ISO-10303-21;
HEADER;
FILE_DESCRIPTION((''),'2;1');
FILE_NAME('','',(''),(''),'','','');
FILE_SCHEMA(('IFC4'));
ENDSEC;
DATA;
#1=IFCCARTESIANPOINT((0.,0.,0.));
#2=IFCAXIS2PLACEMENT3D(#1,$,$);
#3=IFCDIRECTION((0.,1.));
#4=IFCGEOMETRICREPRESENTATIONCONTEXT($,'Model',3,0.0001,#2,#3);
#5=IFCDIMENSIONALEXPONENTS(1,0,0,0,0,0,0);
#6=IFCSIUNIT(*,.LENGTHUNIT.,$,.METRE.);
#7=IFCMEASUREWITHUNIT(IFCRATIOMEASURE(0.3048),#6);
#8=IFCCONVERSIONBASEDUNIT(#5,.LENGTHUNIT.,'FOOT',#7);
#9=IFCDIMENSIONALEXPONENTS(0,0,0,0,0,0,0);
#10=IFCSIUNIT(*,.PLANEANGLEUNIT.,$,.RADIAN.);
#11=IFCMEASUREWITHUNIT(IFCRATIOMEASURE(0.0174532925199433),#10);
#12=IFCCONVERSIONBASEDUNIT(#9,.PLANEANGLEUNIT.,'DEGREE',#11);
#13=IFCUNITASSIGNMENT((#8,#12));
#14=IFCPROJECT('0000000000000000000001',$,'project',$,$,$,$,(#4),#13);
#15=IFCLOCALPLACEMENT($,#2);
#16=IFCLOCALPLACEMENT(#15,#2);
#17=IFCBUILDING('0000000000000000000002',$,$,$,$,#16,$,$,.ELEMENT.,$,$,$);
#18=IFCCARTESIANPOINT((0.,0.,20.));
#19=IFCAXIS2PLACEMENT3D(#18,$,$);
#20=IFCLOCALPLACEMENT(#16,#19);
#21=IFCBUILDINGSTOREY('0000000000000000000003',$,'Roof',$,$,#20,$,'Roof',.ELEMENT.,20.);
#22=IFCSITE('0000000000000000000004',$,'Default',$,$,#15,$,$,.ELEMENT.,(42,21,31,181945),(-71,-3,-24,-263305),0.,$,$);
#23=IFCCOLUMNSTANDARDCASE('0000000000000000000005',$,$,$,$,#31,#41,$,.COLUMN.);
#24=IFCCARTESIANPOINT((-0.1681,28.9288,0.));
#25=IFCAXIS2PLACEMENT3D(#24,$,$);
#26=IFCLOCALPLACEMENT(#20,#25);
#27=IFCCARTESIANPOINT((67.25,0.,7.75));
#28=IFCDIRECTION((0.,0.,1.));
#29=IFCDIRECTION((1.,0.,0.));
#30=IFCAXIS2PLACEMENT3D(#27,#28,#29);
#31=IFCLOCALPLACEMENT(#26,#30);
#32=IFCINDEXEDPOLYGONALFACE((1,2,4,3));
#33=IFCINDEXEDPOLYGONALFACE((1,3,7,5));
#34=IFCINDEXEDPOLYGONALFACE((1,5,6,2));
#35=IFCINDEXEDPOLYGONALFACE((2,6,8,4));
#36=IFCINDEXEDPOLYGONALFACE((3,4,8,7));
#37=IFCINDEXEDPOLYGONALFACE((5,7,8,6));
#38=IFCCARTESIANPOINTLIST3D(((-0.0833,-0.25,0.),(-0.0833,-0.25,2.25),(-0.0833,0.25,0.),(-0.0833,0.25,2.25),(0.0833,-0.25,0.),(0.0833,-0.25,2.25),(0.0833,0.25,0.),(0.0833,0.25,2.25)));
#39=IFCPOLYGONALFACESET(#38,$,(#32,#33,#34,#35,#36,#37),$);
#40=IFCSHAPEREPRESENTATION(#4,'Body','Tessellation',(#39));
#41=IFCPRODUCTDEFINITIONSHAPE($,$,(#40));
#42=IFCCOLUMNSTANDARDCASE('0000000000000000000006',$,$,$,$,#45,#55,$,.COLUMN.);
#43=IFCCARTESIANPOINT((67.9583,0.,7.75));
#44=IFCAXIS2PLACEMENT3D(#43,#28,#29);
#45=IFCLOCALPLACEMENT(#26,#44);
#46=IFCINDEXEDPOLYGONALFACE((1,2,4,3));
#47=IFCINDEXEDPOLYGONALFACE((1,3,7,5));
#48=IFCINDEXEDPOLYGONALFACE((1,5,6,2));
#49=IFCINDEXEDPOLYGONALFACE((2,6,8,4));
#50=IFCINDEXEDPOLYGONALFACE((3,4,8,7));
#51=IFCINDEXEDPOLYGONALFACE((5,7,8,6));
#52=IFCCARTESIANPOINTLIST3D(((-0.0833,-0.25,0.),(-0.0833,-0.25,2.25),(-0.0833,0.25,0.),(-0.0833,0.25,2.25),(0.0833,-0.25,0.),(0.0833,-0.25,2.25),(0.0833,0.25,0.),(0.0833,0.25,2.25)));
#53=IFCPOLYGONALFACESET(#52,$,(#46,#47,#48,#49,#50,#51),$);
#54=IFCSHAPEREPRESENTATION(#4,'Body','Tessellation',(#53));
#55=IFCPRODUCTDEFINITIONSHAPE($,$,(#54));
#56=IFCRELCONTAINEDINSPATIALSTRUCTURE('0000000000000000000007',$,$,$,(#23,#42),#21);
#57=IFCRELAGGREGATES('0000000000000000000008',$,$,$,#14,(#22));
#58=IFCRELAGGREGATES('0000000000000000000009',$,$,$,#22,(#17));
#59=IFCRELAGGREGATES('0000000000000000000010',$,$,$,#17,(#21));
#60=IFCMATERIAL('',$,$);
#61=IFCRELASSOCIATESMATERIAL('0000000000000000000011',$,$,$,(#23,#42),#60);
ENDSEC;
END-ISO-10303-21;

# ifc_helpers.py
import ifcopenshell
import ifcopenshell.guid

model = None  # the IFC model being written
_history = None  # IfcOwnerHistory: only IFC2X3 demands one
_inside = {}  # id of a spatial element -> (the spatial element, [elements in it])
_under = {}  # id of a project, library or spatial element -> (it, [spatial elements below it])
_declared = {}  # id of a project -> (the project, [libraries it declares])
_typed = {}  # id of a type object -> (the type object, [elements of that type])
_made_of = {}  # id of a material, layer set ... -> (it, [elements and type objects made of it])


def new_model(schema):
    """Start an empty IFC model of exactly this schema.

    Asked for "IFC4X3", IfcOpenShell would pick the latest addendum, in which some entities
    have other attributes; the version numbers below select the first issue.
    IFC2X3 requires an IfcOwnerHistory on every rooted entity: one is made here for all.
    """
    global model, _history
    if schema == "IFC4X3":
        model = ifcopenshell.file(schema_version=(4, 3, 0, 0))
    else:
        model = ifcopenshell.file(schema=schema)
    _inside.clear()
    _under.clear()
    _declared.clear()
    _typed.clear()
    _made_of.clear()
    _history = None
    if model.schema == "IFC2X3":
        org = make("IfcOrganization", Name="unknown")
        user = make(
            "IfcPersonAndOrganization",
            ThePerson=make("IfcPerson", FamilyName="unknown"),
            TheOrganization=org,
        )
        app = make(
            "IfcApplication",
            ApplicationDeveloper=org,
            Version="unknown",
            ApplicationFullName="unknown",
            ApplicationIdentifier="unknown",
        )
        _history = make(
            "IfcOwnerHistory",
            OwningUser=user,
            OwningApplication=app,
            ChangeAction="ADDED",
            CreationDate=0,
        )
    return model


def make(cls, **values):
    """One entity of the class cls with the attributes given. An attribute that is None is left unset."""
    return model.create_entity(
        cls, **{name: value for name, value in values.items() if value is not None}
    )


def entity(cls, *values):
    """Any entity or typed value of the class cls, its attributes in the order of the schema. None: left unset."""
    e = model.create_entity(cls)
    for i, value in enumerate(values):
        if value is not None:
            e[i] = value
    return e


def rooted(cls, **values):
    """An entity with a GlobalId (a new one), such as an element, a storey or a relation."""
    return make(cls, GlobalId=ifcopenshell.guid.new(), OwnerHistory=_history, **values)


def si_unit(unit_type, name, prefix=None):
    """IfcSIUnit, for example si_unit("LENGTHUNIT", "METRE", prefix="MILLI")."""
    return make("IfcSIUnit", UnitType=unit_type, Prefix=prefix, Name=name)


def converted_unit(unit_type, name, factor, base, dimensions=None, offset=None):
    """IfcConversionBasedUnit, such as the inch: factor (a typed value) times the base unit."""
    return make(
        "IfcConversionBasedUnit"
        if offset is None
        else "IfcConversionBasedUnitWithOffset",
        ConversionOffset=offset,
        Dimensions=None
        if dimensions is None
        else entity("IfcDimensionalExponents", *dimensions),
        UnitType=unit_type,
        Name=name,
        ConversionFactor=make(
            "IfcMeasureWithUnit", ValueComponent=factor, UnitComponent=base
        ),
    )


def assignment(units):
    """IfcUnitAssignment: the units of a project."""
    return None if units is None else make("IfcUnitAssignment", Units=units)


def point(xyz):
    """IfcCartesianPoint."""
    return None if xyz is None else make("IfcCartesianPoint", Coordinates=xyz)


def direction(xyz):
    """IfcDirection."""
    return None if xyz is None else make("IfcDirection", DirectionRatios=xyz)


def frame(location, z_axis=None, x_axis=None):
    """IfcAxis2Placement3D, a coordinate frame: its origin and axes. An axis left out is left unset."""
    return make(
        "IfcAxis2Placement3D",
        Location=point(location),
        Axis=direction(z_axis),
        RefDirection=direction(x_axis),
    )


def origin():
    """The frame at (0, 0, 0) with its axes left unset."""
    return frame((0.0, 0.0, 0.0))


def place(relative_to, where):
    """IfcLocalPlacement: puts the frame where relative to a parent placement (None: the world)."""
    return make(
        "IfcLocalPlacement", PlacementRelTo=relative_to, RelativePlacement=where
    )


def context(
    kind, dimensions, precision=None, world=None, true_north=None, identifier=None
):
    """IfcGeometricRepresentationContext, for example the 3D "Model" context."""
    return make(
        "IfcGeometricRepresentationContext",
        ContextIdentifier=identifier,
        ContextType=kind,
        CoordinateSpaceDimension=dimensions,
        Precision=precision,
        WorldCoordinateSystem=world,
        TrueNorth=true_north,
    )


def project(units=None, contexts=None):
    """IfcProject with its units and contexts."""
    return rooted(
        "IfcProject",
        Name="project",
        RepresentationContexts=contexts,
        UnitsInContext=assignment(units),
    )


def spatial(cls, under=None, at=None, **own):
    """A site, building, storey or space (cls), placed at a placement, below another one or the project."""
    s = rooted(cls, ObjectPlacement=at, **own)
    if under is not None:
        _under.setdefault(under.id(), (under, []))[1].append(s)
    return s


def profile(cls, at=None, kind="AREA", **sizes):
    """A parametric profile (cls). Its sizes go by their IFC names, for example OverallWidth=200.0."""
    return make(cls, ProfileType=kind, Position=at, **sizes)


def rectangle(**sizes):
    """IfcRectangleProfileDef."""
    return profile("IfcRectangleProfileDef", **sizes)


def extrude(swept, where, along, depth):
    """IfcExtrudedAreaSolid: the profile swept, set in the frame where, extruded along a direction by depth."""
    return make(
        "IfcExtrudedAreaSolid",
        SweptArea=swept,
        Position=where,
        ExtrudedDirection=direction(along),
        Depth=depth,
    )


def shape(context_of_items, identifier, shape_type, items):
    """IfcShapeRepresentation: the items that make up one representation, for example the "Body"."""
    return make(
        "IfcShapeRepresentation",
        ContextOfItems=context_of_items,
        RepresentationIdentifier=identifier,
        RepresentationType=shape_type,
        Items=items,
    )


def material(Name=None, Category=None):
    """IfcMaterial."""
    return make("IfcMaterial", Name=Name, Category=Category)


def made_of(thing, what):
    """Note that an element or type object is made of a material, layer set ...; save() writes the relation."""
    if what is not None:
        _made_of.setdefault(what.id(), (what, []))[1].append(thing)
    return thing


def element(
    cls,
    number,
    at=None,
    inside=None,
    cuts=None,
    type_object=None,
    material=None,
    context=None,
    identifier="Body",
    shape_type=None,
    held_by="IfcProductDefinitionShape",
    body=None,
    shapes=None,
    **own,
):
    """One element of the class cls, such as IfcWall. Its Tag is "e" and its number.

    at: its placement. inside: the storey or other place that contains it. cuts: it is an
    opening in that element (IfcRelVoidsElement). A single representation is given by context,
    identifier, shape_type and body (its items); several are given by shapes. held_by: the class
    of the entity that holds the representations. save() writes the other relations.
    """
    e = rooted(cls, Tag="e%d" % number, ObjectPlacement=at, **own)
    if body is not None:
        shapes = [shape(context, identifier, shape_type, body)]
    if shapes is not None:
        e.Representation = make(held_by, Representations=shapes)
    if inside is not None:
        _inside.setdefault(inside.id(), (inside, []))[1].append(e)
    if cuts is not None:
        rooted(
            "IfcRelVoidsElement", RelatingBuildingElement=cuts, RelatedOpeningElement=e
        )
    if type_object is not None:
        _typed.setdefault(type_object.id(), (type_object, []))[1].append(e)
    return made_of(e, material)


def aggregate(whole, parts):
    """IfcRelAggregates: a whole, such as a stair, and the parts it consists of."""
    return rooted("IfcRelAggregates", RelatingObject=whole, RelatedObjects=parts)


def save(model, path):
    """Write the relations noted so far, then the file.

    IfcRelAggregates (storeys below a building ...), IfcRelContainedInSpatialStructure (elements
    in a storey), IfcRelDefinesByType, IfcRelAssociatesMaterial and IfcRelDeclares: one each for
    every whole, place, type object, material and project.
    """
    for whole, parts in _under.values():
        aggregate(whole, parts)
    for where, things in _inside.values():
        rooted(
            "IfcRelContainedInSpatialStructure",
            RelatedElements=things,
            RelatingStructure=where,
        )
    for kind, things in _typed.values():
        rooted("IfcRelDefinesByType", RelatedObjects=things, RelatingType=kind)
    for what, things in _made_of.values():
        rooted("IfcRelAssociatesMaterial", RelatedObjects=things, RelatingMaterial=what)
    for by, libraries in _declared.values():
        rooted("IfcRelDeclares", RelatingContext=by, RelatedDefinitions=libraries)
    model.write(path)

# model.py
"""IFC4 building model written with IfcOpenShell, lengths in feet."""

from ifc_helpers import new_model, entity, si_unit, converted_unit, direction, frame, origin, place, context, project, spatial, rectangle, extrude, material, element, save


model = new_model("IFC4")

# Units and contexts
model_context = context("Model", 3, precision=0.0001, world=origin(), true_north=direction((0.0, 1.0)))
ifc_project = project(units=[converted_unit("LENGTHUNIT", "FOOT", entity("IfcRatioMeasure", 0.3048), si_unit("LENGTHUNIT", "METRE"), dimensions=[1, 0, 0, 0, 0, 0, 0]), converted_unit("PLANEANGLEUNIT", "DEGREE", entity("IfcRatioMeasure", 0.0174532925199433), si_unit("PLANEANGLEUNIT", "RADIAN"), dimensions=[0, 0, 0, 0, 0, 0, 0])], contexts=[model_context])

# Site, building, storey
site_placement = place(None, origin())
site = spatial("IfcSite", under=ifc_project, at=site_placement, Name="Default", CompositionType="ELEMENT", RefLatitude=(42, 21, 31, 181945), RefLongitude=(-71, -3, -24, -263305), RefElevation=0.0)
building_placement = place(site_placement, origin())
building = spatial("IfcBuilding", under=site, at=building_placement, CompositionType="ELEMENT")
storey_placement = place(building_placement, frame((0.0, 0.0, 20.0)))
storey = spatial("IfcBuildingStorey", under=building, at=storey_placement, Name="Roof", LongName="Roof", CompositionType="ELEMENT", Elevation=20.0)

# Columns
placement = place(storey_placement, frame((-0.1681, 28.9288, 0.0)))
ifc_material_1 = material(Name="")
for number, where, z_axis, x_axis in (
    (1, (67.25, 0.0, 7.75), (0.0, 0.0, 1.0), (1.0, 0.0, 0.0)),
    (2, (67.9583, 0.0, 7.75), (0.0, 0.0, 1.0), (1.0, 0.0, 0.0)),
):
    element("IfcColumnStandardCase", number, at=place(placement, frame(where, z_axis=z_axis, x_axis=x_axis)), inside=storey, material=ifc_material_1, PredefinedType="COLUMN", context=model_context, shape_type="SweptSolid", body=[
        extrude(rectangle(XDim=0.1667, YDim=0.5), origin(), (0.0, 0.0, 1.0), 2.25),
    ])

save(model, "model.ifc")
